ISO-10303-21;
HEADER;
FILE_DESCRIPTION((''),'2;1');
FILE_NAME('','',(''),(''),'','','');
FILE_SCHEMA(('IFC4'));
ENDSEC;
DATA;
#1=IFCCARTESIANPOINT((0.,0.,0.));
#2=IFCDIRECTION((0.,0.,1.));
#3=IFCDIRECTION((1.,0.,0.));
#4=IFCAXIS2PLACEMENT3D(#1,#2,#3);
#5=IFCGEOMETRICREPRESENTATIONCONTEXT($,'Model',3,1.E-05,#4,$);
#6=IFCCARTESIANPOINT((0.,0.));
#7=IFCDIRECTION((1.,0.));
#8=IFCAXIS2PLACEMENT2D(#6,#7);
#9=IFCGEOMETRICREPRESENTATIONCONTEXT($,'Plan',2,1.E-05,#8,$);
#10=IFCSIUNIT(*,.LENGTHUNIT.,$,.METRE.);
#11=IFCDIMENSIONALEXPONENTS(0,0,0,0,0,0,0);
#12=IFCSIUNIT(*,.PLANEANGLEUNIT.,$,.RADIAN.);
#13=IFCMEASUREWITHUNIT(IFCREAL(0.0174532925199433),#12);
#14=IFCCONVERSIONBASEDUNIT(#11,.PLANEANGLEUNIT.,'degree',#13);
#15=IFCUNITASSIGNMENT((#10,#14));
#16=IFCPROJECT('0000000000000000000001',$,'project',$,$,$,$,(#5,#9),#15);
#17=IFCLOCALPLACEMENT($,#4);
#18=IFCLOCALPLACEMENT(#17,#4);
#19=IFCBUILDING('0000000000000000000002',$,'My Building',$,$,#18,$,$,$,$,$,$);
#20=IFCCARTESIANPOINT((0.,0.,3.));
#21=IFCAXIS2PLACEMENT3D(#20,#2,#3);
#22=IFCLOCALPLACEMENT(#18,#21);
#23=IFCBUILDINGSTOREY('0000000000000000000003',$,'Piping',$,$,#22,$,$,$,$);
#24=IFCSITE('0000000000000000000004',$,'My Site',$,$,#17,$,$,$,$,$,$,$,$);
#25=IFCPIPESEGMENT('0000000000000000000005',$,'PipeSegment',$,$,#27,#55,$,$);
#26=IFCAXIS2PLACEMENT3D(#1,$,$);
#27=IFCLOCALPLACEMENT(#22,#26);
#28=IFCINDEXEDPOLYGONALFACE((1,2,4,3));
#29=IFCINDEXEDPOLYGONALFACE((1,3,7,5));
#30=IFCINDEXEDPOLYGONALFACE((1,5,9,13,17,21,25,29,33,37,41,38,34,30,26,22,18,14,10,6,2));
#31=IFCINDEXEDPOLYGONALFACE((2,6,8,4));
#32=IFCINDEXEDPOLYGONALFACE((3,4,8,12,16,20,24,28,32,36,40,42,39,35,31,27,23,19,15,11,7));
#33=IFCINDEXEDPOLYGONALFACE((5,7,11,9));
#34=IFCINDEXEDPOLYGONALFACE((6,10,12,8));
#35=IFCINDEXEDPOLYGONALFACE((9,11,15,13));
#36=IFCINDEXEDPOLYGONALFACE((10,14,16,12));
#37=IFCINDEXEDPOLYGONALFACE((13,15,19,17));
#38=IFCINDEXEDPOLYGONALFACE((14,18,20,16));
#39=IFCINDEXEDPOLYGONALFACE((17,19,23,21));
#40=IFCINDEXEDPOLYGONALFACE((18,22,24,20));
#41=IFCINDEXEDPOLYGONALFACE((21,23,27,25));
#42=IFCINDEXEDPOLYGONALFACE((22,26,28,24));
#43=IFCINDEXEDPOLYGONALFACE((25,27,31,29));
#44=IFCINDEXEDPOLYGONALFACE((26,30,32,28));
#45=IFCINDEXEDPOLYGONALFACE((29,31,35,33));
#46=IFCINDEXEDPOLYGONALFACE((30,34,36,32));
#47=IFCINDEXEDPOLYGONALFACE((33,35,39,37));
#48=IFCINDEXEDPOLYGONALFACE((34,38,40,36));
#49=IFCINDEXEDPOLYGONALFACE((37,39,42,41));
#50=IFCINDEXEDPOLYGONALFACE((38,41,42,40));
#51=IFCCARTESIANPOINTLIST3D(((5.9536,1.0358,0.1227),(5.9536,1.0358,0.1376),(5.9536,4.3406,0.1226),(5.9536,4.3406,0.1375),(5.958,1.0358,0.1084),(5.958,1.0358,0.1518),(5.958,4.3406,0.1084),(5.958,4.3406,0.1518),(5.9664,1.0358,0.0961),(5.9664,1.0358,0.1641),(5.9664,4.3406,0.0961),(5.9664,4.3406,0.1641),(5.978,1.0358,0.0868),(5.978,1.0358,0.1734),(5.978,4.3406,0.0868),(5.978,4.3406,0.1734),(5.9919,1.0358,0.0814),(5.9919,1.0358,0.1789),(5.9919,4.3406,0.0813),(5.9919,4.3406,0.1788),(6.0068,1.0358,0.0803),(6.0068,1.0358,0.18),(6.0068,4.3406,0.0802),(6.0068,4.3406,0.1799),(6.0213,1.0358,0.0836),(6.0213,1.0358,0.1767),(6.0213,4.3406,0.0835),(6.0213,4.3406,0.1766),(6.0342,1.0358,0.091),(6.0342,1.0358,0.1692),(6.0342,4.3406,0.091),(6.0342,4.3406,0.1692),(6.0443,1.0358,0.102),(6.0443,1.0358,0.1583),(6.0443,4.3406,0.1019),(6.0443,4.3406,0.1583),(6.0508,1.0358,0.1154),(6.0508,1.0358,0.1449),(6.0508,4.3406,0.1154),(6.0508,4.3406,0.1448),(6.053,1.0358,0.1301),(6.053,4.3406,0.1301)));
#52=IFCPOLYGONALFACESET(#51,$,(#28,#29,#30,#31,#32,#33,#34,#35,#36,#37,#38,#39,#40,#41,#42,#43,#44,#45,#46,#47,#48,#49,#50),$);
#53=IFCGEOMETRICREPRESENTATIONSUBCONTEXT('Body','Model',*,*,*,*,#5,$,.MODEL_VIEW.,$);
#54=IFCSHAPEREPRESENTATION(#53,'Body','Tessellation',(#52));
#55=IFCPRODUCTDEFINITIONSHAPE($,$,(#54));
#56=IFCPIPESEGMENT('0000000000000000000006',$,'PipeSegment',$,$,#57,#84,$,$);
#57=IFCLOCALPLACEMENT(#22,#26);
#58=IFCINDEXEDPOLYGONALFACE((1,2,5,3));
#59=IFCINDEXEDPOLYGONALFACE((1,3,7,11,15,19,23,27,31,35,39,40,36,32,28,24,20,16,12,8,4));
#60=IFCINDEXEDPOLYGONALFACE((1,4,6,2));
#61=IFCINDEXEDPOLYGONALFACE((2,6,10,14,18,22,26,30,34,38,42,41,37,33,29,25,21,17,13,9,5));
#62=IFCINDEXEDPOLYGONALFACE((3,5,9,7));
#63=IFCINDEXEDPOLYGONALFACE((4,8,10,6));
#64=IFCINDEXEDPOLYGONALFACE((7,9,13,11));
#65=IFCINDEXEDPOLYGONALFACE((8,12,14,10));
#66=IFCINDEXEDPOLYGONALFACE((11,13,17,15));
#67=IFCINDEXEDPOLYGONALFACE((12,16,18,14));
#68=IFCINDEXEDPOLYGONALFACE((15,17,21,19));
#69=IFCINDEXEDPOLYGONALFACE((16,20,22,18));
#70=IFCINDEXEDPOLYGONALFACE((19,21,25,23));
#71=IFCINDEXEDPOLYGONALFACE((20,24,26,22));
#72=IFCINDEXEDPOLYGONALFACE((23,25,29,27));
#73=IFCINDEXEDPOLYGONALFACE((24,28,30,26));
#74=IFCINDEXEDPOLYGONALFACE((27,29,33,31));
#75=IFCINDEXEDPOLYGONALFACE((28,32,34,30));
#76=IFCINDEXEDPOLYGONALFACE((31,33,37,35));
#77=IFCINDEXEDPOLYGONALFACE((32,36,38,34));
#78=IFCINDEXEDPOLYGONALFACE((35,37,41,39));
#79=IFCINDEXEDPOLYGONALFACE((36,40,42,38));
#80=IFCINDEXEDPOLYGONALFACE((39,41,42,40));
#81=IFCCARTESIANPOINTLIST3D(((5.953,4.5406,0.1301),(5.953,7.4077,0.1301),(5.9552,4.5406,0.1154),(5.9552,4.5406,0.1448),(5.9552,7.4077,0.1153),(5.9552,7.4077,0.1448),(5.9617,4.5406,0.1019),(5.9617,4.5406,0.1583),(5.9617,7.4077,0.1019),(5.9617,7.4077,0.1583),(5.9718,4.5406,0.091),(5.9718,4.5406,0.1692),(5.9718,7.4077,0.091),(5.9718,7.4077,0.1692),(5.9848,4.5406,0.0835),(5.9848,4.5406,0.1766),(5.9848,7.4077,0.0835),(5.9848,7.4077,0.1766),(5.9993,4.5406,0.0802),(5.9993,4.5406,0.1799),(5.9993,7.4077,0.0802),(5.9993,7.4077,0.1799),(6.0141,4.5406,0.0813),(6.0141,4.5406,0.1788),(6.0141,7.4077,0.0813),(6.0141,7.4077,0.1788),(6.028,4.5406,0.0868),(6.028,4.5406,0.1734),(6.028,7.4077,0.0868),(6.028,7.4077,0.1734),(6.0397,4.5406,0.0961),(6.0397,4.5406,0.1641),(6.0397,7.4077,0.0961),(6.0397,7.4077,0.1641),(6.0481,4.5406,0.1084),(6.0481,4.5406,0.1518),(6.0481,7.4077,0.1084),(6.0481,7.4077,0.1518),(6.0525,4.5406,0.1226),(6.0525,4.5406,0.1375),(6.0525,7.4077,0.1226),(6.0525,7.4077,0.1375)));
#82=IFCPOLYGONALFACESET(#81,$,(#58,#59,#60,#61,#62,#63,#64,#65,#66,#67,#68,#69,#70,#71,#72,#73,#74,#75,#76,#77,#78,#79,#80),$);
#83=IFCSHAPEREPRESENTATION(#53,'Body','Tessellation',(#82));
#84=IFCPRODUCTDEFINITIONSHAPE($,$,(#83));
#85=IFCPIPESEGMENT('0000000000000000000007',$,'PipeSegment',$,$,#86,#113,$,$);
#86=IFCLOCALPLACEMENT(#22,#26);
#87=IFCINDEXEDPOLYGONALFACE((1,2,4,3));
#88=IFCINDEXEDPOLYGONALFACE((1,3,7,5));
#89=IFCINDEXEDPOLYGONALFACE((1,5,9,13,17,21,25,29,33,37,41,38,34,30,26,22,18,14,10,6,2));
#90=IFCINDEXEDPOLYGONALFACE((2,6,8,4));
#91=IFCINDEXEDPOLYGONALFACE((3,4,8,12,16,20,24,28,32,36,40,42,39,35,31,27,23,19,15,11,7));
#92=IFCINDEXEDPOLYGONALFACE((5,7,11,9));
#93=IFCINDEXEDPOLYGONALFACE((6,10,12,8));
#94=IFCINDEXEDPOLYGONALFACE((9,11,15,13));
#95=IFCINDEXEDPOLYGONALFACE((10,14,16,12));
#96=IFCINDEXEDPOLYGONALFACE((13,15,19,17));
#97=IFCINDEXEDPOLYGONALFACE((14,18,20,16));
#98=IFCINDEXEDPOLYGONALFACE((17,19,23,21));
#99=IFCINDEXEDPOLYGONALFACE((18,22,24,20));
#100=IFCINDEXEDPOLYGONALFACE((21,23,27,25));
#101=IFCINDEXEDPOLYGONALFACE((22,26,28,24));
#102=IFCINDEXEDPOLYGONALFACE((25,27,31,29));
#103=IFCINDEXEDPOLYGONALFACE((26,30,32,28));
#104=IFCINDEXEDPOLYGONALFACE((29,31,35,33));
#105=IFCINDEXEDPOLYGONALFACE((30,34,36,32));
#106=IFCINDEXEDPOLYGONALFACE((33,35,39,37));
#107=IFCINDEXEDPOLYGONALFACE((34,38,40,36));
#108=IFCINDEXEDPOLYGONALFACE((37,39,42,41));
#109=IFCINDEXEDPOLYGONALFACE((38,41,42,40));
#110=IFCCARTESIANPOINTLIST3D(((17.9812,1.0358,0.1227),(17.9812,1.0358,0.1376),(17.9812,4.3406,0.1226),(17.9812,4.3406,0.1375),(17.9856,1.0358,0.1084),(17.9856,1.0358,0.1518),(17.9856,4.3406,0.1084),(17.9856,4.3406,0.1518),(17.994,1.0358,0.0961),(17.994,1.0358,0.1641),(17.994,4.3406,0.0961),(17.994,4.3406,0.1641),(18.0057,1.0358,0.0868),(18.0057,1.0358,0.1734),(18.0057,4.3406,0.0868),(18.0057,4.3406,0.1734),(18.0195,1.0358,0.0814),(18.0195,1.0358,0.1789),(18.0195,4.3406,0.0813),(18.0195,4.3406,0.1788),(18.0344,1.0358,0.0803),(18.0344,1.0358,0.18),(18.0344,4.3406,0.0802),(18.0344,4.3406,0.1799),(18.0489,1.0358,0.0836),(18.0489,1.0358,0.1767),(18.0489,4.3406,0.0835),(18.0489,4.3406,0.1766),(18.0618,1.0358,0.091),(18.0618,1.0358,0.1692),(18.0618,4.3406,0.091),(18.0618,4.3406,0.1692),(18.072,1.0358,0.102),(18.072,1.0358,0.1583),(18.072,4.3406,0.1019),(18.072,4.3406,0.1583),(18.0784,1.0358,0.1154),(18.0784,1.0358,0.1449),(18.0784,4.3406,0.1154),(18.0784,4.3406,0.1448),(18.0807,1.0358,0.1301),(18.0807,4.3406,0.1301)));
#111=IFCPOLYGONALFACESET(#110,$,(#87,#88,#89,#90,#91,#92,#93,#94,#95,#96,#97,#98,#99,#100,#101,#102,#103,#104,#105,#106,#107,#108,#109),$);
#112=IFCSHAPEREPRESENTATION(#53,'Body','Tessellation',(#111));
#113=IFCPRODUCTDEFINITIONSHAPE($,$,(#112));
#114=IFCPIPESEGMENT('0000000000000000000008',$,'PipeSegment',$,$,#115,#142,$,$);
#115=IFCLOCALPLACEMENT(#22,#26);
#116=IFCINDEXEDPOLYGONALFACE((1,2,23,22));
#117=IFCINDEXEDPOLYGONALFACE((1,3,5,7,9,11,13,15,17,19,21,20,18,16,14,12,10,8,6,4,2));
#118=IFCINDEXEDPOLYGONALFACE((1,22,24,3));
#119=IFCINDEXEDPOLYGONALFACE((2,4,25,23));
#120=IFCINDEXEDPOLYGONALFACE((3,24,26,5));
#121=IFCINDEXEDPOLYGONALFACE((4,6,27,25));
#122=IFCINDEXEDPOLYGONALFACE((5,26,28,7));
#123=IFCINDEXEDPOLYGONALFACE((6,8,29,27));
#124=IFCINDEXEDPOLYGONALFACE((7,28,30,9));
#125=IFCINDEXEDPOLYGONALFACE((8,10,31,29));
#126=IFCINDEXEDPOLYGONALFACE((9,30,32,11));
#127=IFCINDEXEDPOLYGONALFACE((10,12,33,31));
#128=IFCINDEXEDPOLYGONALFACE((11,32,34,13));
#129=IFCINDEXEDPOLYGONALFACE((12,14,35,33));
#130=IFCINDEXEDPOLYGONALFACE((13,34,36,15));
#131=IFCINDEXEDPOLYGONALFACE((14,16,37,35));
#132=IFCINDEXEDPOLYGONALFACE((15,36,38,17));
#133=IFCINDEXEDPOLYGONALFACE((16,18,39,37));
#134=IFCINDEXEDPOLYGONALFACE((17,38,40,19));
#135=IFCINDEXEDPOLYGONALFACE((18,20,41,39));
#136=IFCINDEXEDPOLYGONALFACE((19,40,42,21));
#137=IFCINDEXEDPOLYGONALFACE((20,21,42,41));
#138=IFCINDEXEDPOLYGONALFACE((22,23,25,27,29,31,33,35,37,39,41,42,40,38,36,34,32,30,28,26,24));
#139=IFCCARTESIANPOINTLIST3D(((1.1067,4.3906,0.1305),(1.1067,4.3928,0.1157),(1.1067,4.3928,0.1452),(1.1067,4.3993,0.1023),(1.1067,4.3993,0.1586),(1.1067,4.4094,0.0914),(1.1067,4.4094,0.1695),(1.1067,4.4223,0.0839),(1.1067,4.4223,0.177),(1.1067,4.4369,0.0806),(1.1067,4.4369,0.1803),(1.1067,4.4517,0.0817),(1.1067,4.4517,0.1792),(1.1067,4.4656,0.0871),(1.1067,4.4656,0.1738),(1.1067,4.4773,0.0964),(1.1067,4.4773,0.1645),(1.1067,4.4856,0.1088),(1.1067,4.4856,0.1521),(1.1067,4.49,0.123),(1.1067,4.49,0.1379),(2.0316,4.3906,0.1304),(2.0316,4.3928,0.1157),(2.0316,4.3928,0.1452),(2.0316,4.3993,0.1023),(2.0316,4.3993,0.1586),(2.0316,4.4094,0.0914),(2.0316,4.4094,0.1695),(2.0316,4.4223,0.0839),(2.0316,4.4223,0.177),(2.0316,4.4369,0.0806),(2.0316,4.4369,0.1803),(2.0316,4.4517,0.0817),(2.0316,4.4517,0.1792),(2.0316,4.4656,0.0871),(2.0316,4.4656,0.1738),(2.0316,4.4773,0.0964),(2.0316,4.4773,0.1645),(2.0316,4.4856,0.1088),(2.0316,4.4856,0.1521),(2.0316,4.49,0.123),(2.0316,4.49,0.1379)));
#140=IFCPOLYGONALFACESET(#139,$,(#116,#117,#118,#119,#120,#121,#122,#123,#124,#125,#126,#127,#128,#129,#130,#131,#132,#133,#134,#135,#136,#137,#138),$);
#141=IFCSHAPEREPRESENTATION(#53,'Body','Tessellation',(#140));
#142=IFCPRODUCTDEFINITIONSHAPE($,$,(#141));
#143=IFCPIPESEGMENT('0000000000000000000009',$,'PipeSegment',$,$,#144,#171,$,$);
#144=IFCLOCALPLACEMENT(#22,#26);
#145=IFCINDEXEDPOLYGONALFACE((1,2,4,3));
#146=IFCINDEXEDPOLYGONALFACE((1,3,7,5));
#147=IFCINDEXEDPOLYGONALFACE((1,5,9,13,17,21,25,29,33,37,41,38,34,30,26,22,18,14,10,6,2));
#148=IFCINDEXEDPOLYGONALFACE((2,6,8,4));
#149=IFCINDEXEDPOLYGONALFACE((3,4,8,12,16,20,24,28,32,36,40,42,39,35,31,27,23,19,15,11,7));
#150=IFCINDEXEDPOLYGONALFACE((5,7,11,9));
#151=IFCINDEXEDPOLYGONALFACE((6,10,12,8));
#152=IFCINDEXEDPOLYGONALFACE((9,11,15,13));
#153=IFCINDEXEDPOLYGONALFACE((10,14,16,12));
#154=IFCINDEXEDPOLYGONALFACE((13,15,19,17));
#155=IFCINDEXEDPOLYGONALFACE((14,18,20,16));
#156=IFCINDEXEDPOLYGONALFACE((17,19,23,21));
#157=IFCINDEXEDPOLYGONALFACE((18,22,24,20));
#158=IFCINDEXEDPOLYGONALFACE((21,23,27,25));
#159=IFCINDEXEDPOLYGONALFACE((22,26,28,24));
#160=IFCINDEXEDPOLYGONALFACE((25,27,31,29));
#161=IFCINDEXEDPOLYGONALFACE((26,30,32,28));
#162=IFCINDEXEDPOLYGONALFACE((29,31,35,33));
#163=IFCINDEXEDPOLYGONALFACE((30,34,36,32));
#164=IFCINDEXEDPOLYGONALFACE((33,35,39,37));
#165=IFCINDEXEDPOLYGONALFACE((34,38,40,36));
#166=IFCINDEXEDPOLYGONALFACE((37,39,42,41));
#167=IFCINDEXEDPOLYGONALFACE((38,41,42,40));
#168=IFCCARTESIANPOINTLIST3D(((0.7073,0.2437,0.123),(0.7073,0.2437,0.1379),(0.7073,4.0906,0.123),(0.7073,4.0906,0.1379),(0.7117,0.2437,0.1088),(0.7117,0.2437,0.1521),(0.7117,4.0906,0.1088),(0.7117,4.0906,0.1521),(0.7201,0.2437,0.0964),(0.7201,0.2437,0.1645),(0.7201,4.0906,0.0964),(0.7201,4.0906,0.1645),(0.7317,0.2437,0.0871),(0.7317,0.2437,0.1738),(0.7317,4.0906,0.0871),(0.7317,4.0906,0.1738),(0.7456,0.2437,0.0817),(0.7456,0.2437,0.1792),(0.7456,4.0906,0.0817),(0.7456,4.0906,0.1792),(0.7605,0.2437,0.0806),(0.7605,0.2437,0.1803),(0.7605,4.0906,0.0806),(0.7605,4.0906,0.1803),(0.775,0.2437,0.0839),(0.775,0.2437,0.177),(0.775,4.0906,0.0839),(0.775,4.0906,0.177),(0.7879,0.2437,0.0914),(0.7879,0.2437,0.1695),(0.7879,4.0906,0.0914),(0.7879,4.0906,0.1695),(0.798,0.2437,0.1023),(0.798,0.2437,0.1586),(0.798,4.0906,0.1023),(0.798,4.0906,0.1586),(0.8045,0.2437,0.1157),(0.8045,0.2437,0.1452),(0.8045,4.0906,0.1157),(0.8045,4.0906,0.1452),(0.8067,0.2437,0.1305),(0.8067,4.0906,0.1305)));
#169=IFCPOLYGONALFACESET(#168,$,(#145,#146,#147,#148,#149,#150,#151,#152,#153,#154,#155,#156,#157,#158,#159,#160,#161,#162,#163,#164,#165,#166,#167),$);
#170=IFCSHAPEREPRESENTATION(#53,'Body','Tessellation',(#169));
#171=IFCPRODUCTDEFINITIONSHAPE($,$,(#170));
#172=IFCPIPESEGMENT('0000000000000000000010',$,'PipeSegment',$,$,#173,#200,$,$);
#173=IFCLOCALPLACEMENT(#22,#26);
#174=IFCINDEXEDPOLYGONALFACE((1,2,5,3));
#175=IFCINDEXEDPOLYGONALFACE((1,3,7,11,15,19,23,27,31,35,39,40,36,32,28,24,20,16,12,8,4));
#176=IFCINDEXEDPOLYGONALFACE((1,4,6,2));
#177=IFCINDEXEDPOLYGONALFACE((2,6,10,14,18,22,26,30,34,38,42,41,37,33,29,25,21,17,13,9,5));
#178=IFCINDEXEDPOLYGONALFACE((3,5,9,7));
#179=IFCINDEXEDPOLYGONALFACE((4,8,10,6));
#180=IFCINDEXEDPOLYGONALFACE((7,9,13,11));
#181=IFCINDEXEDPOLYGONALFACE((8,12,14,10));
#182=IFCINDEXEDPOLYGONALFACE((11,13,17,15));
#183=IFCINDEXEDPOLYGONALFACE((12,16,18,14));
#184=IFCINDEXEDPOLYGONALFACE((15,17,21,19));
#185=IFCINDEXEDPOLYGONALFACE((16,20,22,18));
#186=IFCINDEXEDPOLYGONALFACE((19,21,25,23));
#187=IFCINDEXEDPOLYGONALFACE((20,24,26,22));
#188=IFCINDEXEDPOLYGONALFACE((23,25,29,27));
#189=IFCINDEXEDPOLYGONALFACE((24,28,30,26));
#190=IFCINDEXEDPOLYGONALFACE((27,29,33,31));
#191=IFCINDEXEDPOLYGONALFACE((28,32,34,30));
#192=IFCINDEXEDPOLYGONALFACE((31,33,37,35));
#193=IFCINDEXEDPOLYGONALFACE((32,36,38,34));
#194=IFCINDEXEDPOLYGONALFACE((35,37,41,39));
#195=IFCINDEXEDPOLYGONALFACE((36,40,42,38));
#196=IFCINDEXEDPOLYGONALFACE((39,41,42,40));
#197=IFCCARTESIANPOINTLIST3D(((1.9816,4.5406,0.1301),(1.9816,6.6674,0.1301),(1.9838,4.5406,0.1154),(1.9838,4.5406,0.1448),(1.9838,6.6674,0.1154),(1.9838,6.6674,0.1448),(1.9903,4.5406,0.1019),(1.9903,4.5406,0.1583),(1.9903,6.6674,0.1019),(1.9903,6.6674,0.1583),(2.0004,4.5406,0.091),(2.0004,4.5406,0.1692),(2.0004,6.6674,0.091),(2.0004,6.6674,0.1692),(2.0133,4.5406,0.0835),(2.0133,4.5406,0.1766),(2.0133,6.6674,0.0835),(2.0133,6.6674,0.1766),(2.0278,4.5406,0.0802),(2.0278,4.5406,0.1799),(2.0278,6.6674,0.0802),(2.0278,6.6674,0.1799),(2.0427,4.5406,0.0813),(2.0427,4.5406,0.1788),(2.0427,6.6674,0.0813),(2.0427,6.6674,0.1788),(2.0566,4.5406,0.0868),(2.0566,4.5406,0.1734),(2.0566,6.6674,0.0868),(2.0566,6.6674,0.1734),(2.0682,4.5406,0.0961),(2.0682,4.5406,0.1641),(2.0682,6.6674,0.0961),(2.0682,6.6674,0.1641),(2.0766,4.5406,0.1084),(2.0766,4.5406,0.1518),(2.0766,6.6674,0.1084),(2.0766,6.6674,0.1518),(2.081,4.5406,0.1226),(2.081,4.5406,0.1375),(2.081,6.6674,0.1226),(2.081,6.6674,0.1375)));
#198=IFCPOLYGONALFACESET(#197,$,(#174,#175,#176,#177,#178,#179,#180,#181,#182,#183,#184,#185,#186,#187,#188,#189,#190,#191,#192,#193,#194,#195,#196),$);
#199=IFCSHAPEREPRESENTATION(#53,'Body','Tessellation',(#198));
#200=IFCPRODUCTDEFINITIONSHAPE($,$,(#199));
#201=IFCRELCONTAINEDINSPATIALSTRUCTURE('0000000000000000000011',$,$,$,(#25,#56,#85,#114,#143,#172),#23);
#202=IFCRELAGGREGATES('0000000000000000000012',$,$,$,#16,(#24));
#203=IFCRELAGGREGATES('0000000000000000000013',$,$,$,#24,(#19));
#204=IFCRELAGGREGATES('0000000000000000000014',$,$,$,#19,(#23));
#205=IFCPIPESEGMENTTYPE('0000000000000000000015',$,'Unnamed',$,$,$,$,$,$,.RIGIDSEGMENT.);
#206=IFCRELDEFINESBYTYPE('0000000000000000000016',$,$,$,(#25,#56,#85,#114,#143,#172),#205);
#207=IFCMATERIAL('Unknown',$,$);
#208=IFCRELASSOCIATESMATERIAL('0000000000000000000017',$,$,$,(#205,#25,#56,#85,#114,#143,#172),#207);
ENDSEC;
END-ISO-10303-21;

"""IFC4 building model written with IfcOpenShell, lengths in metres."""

from ifc_helpers import new_model, entity, si_unit, converted_unit, frame, origin_with_axes, origin_2d_with_axis, place, context, subcontext, project, spatial, circle, extrude, material, material_profile, profile_set, profile_usage, type_object, element, save


model = new_model("IFC4")

# Units and contexts
model_context = context("Model", 3, precision=1e-05, world=origin_with_axes())
plan_context = context("Plan", 2, precision=1e-05, world=origin_2d_with_axis())
body_context = subcontext(model_context, "Body", "Model", "MODEL_VIEW")
ifc_project = project(units=[si_unit("LENGTHUNIT", "METRE"), converted_unit("PLANEANGLEUNIT", "degree", entity("IfcReal", 0.0174532925199433), si_unit("PLANEANGLEUNIT", "RADIAN"), dimensions=[0, 0, 0, 0, 0, 0, 0])], contexts=[model_context, plan_context])

# Site, building, storey
site_placement = place(None, origin_with_axes())
site = spatial("IfcSite", under=ifc_project, at=site_placement, Name="My Site")
building_placement = place(site_placement, origin_with_axes())
building = spatial("IfcBuilding", under=site, at=building_placement, Name="My Building")
storey_placement = place(building_placement, frame((0.0, 0.0, 3.0), z_axis=(0.0, 0.0, 1.0), x_axis=(1.0, 0.0, 0.0)))
storey = spatial("IfcBuildingStorey", under=building, at=storey_placement, Name="Piping")

# Pipe segments
ifc_material = material(Name="Unknown")
ifc_material_profile_1 = material_profile(ifc_material, circle(Radius=0.05))
ifc_profile_set_1 = profile_set([ifc_material_profile_1])
pipe_segment_type = type_object("IfcPipeSegmentType", Name="Unnamed", PredefinedType="RIGIDSEGMENT", material=ifc_profile_set_1)
ifc_profile_usage_1 = profile_usage(ifc_profile_set_1, cardinal=5)
pipe_segment_1_placement = place(storey_placement, frame((6.003, 4.3406, 0.1301), z_axis=(0.0, -1.0, 0.000015), x_axis=(1.0, 0.0, 0.0)))
element("IfcPipeSegment", 1, at=pipe_segment_1_placement, inside=storey, type_object=pipe_segment_type, material=ifc_profile_usage_1, Name="PipeSegment", context=body_context, shape_type="SweptSolid", body=[
    extrude(circle(Radius=0.05), origin_with_axes(), (0.0, 0.0, 1.0), 3.3048),
])
ifc_profile_usage_2 = profile_usage(ifc_profile_set_1, cardinal=5)
pipe_segment_2_placement = place(storey_placement, frame((6.003, 4.5406, 0.1301), z_axis=(0.0, 1.0, -0.000001), x_axis=(-1.0, 0.0, 0.0)))
element("IfcPipeSegment", 2, at=pipe_segment_2_placement, inside=storey, type_object=pipe_segment_type, material=ifc_profile_usage_2, Name="PipeSegment", context=body_context, shape_type="SweptSolid", body=[
    extrude(circle(Radius=0.05), origin_with_axes(), (0.0, 0.0, 1.0), 2.8671),
])
ifc_profile_usage_3 = profile_usage(ifc_profile_set_1, cardinal=5)
pipe_segment_3_placement = place(storey_placement, frame((18.0307, 4.3406, 0.1301), z_axis=(0.0, -1.0, 0.000015), x_axis=(1.0, 0.0, 0.0)))
element("IfcPipeSegment", 3, at=pipe_segment_3_placement, inside=storey, type_object=pipe_segment_type, material=ifc_profile_usage_3, Name="PipeSegment", context=body_context, shape_type="SweptSolid", body=[
    extrude(circle(Radius=0.05), origin_with_axes(), (0.0, 0.0, 1.0), 3.3048),
])
ifc_profile_usage_4 = profile_usage(ifc_profile_set_1, cardinal=5)
pipe_segment_4_placement = place(storey_placement, frame((2.0316, 4.4406, 0.1304), z_axis=(-1.0, -0.000001, 0.000001), x_axis=(0.000001, -1.0, 0.0)))
element("IfcPipeSegment", 4, at=pipe_segment_4_placement, inside=storey, type_object=pipe_segment_type, material=ifc_profile_usage_4, Name="PipeSegment", context=body_context, shape_type="SweptSolid", body=[
    extrude(circle(Radius=0.05), origin_with_axes(), (0.0, 0.0, 1.0), 0.9248),
])
ifc_profile_usage_5 = profile_usage(ifc_profile_set_1, cardinal=5)
pipe_segment_5_placement = place(storey_placement, frame((0.7567, 4.0906, 0.1305), z_axis=(0.0, -1.0, 0.0), x_axis=(1.0, 0.0, 0.0)))
element("IfcPipeSegment", 5, at=pipe_segment_5_placement, inside=storey, type_object=pipe_segment_type, material=ifc_profile_usage_5, Name="PipeSegment", context=body_context, shape_type="SweptSolid", body=[
    extrude(circle(Radius=0.05), origin_with_axes(), (0.0, 0.0, 1.0), 3.8469),
])
ifc_profile_usage_6 = profile_usage(ifc_profile_set_1, cardinal=5)
pipe_segment_6_placement = place(storey_placement, frame((2.0316, 4.5406, 0.1301), z_axis=(0.0, 1.0, 0.0), x_axis=(-1.0, 0.0, 0.0)))
element("IfcPipeSegment", 6, at=pipe_segment_6_placement, inside=storey, type_object=pipe_segment_type, material=ifc_profile_usage_6, Name="PipeSegment", context=body_context, shape_type="SweptSolid", body=[
    extrude(circle(Radius=0.05), origin_with_axes(), (0.0, 0.0, 1.0), 2.1268),
])

save(model, "model.ifc")
